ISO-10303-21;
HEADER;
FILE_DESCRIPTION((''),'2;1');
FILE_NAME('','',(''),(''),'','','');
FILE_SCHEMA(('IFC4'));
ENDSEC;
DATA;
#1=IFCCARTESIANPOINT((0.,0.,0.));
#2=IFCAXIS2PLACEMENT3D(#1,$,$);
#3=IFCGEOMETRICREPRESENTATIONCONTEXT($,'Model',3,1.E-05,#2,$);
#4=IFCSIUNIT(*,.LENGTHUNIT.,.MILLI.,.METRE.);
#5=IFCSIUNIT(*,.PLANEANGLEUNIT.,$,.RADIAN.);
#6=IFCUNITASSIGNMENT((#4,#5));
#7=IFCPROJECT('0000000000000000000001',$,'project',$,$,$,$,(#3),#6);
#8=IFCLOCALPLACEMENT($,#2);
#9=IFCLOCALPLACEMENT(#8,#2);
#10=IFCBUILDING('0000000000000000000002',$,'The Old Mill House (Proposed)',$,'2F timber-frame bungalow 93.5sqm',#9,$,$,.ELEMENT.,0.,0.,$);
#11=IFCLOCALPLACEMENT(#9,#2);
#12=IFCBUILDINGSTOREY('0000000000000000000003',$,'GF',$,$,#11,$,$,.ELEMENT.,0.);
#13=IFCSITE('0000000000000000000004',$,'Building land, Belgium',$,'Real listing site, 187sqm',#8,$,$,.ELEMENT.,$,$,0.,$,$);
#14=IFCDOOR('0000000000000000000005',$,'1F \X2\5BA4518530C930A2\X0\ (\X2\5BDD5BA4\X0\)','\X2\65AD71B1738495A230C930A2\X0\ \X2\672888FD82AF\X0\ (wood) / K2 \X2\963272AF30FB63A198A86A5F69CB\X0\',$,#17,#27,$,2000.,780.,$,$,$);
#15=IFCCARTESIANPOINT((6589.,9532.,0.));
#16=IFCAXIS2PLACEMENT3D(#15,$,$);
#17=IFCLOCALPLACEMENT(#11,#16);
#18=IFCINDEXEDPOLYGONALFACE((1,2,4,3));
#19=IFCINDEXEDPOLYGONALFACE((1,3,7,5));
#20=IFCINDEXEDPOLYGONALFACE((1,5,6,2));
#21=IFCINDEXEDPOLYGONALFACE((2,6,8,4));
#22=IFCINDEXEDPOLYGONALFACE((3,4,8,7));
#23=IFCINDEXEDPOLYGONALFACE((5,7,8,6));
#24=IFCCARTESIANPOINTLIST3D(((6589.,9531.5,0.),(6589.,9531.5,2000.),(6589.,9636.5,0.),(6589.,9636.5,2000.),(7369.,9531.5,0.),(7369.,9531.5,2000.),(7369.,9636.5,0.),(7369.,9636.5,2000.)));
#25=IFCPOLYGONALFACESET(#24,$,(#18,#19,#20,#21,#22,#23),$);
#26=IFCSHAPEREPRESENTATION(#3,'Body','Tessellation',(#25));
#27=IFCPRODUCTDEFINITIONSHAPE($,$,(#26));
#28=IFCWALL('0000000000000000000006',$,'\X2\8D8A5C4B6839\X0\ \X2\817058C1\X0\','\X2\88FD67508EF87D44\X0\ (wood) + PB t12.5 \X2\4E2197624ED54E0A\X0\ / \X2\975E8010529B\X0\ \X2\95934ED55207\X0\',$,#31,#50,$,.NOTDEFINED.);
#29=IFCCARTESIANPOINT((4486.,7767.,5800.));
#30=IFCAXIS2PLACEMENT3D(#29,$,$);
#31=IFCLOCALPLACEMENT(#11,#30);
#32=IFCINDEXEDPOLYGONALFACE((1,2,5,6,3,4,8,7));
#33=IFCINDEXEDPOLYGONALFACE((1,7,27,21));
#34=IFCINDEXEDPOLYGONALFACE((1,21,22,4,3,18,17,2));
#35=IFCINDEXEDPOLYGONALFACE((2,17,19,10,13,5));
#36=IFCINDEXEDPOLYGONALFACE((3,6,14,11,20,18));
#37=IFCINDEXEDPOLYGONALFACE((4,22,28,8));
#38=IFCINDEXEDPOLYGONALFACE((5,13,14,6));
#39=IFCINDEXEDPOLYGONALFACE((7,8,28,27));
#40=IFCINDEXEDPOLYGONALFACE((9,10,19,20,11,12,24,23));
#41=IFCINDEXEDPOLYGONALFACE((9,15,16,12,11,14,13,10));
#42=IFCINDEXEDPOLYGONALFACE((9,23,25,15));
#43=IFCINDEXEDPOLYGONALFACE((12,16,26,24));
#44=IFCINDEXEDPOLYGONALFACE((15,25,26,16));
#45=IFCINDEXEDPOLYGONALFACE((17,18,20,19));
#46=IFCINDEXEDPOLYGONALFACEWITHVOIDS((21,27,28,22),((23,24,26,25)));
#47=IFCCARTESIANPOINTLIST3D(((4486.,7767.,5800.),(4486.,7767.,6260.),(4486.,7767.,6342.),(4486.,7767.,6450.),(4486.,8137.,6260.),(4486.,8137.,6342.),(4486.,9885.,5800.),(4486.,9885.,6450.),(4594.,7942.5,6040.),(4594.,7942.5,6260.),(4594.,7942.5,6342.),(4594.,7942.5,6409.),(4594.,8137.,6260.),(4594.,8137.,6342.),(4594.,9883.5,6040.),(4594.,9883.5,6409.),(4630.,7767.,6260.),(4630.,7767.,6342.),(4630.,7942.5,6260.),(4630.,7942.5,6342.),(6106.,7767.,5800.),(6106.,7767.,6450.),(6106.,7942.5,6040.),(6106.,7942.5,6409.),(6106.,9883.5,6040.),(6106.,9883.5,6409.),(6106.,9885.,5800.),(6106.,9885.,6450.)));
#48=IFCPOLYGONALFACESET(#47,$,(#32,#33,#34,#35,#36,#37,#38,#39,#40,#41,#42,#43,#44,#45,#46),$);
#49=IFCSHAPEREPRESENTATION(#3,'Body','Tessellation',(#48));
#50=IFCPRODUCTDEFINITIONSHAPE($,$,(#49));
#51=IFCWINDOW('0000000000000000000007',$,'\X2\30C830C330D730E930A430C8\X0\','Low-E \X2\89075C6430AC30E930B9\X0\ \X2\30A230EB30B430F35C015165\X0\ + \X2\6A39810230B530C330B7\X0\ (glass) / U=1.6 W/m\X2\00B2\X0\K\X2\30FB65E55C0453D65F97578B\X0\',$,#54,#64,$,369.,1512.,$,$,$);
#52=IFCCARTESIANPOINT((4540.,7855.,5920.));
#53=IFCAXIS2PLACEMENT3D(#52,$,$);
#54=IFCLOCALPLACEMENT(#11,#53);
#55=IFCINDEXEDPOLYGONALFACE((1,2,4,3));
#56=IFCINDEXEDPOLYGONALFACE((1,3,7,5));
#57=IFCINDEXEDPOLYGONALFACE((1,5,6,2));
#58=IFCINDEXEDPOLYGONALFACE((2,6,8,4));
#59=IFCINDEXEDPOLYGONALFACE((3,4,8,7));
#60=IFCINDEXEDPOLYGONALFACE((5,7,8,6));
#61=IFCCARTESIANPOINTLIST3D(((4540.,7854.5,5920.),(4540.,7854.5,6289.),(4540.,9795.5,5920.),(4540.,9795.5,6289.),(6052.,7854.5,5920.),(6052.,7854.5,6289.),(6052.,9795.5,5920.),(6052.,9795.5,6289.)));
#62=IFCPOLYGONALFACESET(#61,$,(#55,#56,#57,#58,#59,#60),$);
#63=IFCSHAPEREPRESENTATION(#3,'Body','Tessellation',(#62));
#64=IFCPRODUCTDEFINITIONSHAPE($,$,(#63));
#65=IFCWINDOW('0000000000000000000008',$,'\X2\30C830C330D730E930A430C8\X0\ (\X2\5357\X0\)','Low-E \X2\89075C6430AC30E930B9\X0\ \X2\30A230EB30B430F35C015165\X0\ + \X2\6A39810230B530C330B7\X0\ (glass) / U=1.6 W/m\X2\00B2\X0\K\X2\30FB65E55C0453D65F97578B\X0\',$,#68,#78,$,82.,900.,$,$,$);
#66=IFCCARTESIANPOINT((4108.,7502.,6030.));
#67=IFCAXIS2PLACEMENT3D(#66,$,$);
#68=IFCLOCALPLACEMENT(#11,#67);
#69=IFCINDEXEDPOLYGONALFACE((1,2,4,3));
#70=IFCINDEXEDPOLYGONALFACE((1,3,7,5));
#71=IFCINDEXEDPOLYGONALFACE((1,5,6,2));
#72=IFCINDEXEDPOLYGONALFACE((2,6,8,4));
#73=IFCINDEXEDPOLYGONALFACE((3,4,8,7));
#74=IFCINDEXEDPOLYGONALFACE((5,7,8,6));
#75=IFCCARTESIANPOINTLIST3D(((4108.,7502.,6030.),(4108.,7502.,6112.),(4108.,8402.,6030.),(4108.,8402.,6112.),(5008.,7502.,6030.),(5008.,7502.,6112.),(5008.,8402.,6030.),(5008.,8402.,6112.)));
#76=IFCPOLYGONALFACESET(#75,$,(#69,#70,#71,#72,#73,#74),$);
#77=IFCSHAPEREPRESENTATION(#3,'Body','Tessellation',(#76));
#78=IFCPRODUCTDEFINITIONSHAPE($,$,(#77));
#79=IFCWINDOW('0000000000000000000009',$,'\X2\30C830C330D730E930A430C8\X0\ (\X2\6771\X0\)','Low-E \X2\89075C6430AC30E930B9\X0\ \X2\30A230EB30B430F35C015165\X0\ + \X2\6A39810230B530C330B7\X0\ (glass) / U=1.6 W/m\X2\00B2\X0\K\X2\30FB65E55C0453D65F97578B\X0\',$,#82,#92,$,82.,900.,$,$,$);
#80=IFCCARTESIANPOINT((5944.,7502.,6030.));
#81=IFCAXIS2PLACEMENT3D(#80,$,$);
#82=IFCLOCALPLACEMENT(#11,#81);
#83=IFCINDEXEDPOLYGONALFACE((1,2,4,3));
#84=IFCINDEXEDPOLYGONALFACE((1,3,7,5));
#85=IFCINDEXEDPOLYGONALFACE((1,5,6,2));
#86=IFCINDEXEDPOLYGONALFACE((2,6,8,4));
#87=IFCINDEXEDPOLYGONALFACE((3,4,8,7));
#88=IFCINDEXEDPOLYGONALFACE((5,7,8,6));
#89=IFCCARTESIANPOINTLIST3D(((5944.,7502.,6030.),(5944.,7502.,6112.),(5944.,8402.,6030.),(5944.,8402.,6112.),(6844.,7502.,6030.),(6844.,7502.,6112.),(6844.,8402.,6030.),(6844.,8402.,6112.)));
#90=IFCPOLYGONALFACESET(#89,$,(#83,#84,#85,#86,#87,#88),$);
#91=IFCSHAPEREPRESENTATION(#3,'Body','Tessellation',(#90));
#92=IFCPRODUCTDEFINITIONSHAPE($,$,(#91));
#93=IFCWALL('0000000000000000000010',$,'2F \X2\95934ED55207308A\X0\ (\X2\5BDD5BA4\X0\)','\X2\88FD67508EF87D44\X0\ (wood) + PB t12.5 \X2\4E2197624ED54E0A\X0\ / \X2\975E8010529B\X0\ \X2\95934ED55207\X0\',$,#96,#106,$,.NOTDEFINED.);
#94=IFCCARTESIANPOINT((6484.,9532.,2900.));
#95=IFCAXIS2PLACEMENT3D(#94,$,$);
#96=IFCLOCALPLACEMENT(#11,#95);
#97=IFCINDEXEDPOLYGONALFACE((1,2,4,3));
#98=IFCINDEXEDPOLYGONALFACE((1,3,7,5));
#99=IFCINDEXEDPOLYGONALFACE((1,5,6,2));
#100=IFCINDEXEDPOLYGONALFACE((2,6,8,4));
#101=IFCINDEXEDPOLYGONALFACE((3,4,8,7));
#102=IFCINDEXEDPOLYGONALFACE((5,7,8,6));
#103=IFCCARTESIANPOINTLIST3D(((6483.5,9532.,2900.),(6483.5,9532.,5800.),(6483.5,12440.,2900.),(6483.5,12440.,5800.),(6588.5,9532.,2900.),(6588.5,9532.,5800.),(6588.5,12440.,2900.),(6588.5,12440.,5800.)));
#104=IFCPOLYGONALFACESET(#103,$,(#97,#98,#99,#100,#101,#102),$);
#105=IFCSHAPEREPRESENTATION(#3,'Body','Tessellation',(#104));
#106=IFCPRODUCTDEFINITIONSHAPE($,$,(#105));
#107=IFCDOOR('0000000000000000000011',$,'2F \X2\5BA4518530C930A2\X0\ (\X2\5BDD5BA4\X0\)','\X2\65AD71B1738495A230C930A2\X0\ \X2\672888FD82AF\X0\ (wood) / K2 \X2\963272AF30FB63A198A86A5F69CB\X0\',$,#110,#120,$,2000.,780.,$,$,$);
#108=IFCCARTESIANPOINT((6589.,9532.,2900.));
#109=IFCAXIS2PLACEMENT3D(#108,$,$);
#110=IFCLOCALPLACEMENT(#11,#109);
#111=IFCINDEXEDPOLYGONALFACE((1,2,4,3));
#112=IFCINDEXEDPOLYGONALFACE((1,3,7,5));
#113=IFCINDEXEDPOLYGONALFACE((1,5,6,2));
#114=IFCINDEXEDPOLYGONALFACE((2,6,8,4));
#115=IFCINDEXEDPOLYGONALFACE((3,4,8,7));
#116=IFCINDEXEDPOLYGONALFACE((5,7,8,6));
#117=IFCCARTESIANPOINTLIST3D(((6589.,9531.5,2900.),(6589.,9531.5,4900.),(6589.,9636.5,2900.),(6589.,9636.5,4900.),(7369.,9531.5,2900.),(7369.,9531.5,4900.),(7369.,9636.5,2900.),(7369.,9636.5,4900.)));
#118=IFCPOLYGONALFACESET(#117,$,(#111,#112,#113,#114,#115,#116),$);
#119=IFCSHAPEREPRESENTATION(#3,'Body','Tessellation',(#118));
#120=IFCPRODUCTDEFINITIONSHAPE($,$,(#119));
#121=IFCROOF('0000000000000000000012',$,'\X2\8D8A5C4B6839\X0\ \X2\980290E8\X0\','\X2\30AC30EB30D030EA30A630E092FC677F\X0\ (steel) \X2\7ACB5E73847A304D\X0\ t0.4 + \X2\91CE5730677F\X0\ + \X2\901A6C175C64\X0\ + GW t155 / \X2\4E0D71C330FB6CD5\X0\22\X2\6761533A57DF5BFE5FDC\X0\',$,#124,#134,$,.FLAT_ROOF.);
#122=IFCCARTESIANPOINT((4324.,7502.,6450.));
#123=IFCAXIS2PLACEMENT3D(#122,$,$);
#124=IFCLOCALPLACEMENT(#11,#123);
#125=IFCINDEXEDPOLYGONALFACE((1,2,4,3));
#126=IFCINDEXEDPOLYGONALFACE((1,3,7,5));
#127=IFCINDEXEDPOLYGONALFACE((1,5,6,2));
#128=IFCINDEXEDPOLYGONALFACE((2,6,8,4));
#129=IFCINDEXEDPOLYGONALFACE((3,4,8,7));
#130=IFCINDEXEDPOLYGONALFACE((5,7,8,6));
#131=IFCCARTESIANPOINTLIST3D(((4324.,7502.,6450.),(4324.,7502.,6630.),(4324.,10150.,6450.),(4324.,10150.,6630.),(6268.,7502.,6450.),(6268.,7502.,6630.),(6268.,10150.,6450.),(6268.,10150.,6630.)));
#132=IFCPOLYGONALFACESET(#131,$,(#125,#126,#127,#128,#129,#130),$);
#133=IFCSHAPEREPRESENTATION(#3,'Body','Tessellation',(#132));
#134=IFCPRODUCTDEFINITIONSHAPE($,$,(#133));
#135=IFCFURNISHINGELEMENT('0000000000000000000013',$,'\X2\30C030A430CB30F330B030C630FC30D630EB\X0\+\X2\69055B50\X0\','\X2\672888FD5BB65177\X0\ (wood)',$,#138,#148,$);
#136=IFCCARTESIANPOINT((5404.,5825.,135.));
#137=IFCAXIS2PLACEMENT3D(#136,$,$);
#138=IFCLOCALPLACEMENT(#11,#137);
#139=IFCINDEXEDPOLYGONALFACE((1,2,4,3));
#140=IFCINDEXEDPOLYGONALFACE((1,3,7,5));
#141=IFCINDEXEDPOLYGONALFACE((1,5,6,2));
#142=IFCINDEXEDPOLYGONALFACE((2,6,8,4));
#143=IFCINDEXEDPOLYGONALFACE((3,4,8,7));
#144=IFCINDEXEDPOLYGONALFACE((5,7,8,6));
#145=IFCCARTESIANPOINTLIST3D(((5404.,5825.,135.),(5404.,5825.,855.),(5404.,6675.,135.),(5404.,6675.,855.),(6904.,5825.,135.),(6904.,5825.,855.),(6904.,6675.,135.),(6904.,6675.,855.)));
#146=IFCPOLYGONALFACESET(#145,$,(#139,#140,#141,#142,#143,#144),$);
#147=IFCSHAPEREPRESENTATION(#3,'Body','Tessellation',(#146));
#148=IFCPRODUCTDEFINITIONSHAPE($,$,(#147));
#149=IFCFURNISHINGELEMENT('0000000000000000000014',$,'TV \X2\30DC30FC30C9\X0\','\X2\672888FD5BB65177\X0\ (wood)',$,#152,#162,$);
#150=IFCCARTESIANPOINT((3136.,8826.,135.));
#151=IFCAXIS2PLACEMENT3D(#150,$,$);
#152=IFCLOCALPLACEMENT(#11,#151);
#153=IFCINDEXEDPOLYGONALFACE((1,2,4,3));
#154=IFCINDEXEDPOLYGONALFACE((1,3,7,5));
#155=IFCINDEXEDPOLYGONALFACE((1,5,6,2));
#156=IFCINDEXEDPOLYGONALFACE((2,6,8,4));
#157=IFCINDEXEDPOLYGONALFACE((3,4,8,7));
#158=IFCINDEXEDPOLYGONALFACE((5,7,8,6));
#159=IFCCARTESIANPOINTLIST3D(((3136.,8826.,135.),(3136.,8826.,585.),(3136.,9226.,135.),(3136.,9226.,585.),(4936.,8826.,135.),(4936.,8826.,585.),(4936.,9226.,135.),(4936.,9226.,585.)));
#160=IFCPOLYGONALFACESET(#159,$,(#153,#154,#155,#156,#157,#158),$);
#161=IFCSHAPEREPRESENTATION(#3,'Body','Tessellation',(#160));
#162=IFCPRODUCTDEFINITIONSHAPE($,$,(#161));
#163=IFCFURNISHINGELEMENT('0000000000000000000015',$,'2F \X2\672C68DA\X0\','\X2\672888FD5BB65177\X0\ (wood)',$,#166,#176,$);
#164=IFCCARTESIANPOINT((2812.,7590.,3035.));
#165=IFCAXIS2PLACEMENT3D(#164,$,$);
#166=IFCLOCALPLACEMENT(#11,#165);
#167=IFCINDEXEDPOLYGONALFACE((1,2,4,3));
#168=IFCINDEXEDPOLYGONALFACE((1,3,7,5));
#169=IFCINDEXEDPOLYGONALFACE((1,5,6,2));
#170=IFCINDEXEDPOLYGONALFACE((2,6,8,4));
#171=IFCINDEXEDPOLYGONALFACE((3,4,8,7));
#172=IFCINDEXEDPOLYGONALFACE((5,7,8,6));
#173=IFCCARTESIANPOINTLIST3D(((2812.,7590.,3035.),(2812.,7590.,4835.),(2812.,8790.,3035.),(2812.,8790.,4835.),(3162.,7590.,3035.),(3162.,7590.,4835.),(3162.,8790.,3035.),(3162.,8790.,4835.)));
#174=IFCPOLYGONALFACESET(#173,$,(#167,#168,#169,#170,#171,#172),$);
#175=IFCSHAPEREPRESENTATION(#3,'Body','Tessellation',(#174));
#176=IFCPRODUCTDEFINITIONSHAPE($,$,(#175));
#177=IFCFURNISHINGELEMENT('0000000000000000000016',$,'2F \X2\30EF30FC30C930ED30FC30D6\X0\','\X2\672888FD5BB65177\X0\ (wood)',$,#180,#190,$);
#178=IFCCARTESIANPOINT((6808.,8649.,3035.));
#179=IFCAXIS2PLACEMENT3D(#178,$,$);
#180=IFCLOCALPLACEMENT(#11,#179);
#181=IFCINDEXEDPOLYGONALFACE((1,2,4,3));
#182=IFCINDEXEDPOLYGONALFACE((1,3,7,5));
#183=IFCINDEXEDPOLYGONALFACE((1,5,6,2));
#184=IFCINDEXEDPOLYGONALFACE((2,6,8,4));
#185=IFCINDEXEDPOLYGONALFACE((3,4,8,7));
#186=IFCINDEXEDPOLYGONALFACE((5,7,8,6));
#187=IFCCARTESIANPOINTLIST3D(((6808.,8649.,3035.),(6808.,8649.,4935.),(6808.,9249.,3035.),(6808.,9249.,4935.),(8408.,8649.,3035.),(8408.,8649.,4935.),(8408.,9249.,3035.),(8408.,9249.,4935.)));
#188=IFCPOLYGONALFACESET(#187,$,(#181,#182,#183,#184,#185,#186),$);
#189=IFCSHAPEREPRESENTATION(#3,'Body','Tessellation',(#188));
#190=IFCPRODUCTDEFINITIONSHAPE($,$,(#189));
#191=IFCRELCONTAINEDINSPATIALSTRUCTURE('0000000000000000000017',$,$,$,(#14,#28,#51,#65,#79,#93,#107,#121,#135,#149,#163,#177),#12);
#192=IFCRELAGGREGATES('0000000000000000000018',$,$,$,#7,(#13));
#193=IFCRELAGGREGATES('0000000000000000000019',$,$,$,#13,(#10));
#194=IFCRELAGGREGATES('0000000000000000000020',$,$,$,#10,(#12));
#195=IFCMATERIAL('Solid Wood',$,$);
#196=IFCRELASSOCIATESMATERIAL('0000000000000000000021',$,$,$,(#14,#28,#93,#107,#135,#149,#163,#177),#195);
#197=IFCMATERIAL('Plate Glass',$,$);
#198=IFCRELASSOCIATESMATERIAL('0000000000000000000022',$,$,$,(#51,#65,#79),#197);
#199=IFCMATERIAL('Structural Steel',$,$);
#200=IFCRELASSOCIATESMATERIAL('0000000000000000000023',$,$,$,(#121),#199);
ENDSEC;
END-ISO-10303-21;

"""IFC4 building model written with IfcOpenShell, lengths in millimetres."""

from ifc_helpers import new_model, si_unit, frame, frame_2d, origin, place, context, project, spatial, rectangle, extrude, material, element, fill, save


model = new_model("IFC4")

# Units and contexts
model_context = context("Model", 3, precision=1e-05, world=origin())
ifc_project = project(units=[si_unit("LENGTHUNIT", "METRE", prefix="MILLI"), si_unit("PLANEANGLEUNIT", "RADIAN")], contexts=[model_context])

# Site, building, storey
site_placement = place(None, origin())
site = spatial("IfcSite", under=ifc_project, at=site_placement, Name="Building land, Belgium", ObjectType="Real listing site, 187sqm", CompositionType="ELEMENT", RefElevation=0.0)
building_placement = place(site_placement, origin())
building = spatial("IfcBuilding", under=site, at=building_placement, Name="The Old Mill House (Proposed)", ObjectType="2F timber-frame bungalow 93.5sqm", CompositionType="ELEMENT", ElevationOfRefHeight=0.0, ElevationOfTerrain=0.0)
storey_placement = place(building_placement, origin())
storey = spatial("IfcBuildingStorey", under=building, at=storey_placement, Name="GF", CompositionType="ELEMENT", Elevation=0.0)

# Shared definitions
ifc_material_1 = material(Name="Solid Wood")

# Door
door_1_placement = place(storey_placement, frame((6589.0, 9532.0, 0.0)))
element("IfcDoor", 1, at=door_1_placement, inside=storey, material=ifc_material_1, Name="1F 室内ドア (寝室)", Description="断熱玄関ドア 木製芯 (wood) / K2 防犯・採風機構", OverallHeight=2000.0, OverallWidth=780.0, context=model_context, shape_type="SweptSolid", body=[
    extrude(rectangle(XDim=780.0, YDim=105.0, at=frame_2d((390.0, 52.0))), frame((6589.0, 9532.0, 0.0)), (0.0, 0.0, 1.0), 2000.0),
])

# Wall, openings, windows
wall_1_placement = place(storey_placement, frame((4486.0, 7767.0, 5800.0)))
wall_1 = element("IfcWall", 2, at=wall_1_placement, inside=storey, material=ifc_material_1, Name="越屋根 腰壁", Description="製材軸組 (wood) + PB t12.5 両面仕上 / 非耐力 間仕切", PredefinedType="NOTDEFINED", context=model_context, shape_type="SweptSolid", body=[
    extrude(rectangle(XDim=1620.0, YDim=2118.0, at=frame_2d((810.0, 1059.0))), frame((4486.0, 7767.0, 5800.0)), (0.0, 0.0, 1.0), 650.0),
])
opening_1_placement = place(storey_placement, frame((4540.0, 7855.0, 5920.0)))
opening_1 = element("IfcOpeningElement", 3, at=opening_1_placement, cuts=wall_1, PredefinedType="NOTDEFINED", context=model_context, shape_type="SweptSolid", body=[
    extrude(rectangle(XDim=1512.0, YDim=1941.0, at=frame_2d((756.0, 970.0))), frame((4540.0, 7855.0, 5920.0)), (0.0, 0.0, 1.0), 369.0),
])
opening_2_placement = place(storey_placement, frame((4108.0, 7502.0, 6030.0)))
opening_2 = element("IfcOpeningElement", 4, at=opening_2_placement, cuts=wall_1, PredefinedType="NOTDEFINED", context=model_context, shape_type="SweptSolid", body=[
    extrude(rectangle(XDim=900.0, YDim=900.0, at=frame_2d((450.0, 450.0))), frame((4108.0, 7502.0, 6030.0)), (0.0, 0.0, 1.0), 82.0),
])
opening_3_placement = place(storey_placement, frame((5944.0, 7502.0, 6030.0)))
opening_3 = element("IfcOpeningElement", 5, at=opening_3_placement, cuts=wall_1, PredefinedType="NOTDEFINED", context=model_context, shape_type="SweptSolid", body=[
    extrude(rectangle(XDim=900.0, YDim=900.0, at=frame_2d((450.0, 450.0))), frame((5944.0, 7502.0, 6030.0)), (0.0, 0.0, 1.0), 82.0),
])
ifc_material_2 = material(Name="Plate Glass")
window_1_placement = place(storey_placement, frame((4540.0, 7855.0, 5920.0)))
window_1 = element("IfcWindow", 6, at=window_1_placement, inside=storey, material=ifc_material_2, Name="トップライト", Description="Low-E 複層ガラス アルゴン封入 + 樹脂サッシ (glass) / U=1.6 W/m²K・日射取得型", OverallHeight=369.0, OverallWidth=1512.0, context=model_context, shape_type="SweptSolid", body=[
    extrude(rectangle(XDim=1512.0, YDim=1941.0, at=frame_2d((756.0, 970.0))), frame((4540.0, 7855.0, 5920.0)), (0.0, 0.0, 1.0), 369.0),
])
fill(opening_1, window_1)
window_2_placement = place(storey_placement, frame((4108.0, 7502.0, 6030.0)))
window_2 = element("IfcWindow", 7, at=window_2_placement, inside=storey, material=ifc_material_2, Name="トップライト (南)", Description="Low-E 複層ガラス アルゴン封入 + 樹脂サッシ (glass) / U=1.6 W/m²K・日射取得型", OverallHeight=82.0, OverallWidth=900.0, context=model_context, shape_type="SweptSolid", body=[
    extrude(rectangle(XDim=900.0, YDim=900.0, at=frame_2d((450.0, 450.0))), frame((4108.0, 7502.0, 6030.0)), (0.0, 0.0, 1.0), 82.0),
])
fill(opening_2, window_2)
window_3_placement = place(storey_placement, frame((5944.0, 7502.0, 6030.0)))
window_3 = element("IfcWindow", 8, at=window_3_placement, inside=storey, material=ifc_material_2, Name="トップライト (東)", Description="Low-E 複層ガラス アルゴン封入 + 樹脂サッシ (glass) / U=1.6 W/m²K・日射取得型", OverallHeight=82.0, OverallWidth=900.0, context=model_context, shape_type="SweptSolid", body=[
    extrude(rectangle(XDim=900.0, YDim=900.0, at=frame_2d((450.0, 450.0))), frame((5944.0, 7502.0, 6030.0)), (0.0, 0.0, 1.0), 82.0),
])
fill(opening_3, window_3)

# Wall
wall_2_placement = place(storey_placement, frame((6484.0, 9532.0, 2900.0)))
element("IfcWall", 9, at=wall_2_placement, inside=storey, material=ifc_material_1, Name="2F 間仕切り (寝室)", Description="製材軸組 (wood) + PB t12.5 両面仕上 / 非耐力 間仕切", PredefinedType="NOTDEFINED", context=model_context, shape_type="SweptSolid", body=[
    extrude(rectangle(XDim=105.0, YDim=2908.0, at=frame_2d((52.0, 1454.0))), frame((6484.0, 9532.0, 2900.0)), (0.0, 0.0, 1.0), 2900.0),
])

# Door
door_2_placement = place(storey_placement, frame((6589.0, 9532.0, 2900.0)))
element("IfcDoor", 10, at=door_2_placement, inside=storey, material=ifc_material_1, Name="2F 室内ドア (寝室)", Description="断熱玄関ドア 木製芯 (wood) / K2 防犯・採風機構", OverallHeight=2000.0, OverallWidth=780.0, context=model_context, shape_type="SweptSolid", body=[
    extrude(rectangle(XDim=780.0, YDim=105.0, at=frame_2d((390.0, 52.0))), frame((6589.0, 9532.0, 2900.0)), (0.0, 0.0, 1.0), 2000.0),
])

# Roof
ifc_material_3 = material(Name="Structural Steel")
roof_placement = place(storey_placement, frame((4324.0, 7502.0, 6450.0)))
element("IfcRoof", 11, at=roof_placement, inside=storey, material=ifc_material_3, Name="越屋根 頂部", Description="ガルバリウム鋼板 (steel) 立平葺き t0.4 + 野地板 + 通気層 + GW t155 / 不燃・法22条区域対応", PredefinedType="FLAT_ROOF", context=model_context, shape_type="SweptSolid", body=[
    extrude(rectangle(XDim=1944.0, YDim=2648.0, at=frame_2d((972.0, 1324.0))), frame((4324.0, 7502.0, 6450.0)), (0.0, 0.0, 1.0), 180.0),
])

# Furnishing elements
furnishing_1_placement = place(storey_placement, frame((5404.0, 5825.0, 135.0)))
element("IfcFurnishingElement", 12, at=furnishing_1_placement, inside=storey, material=ifc_material_1, Name="ダイニングテーブル+椅子", Description="木製家具 (wood)", context=model_context, shape_type="SweptSolid", body=[
    extrude(rectangle(XDim=1500.0, YDim=850.0, at=frame_2d((750.0, 425.0))), frame((5404.0, 5825.0, 135.0)), (0.0, 0.0, 1.0), 720.0),
])
furnishing_2_placement = place(storey_placement, frame((3136.0, 8826.0, 135.0)))
element("IfcFurnishingElement", 13, at=furnishing_2_placement, inside=storey, material=ifc_material_1, Name="TV ボード", Description="木製家具 (wood)", context=model_context, shape_type="SweptSolid", body=[
    extrude(rectangle(XDim=1800.0, YDim=400.0, at=frame_2d((900.0, 200.0))), frame((3136.0, 8826.0, 135.0)), (0.0, 0.0, 1.0), 450.0),
])
furnishing_3_placement = place(storey_placement, frame((2812.0, 7590.0, 3035.0)))
element("IfcFurnishingElement", 14, at=furnishing_3_placement, inside=storey, material=ifc_material_1, Name="2F 本棚", Description="木製家具 (wood)", context=model_context, shape_type="SweptSolid", body=[
    extrude(rectangle(XDim=350.0, YDim=1200.0, at=frame_2d((175.0, 600.0))), frame((2812.0, 7590.0, 3035.0)), (0.0, 0.0, 1.0), 1800.0),
])
furnishing_4_placement = place(storey_placement, frame((6808.0, 8649.0, 3035.0)))
element("IfcFurnishingElement", 15, at=furnishing_4_placement, inside=storey, material=ifc_material_1, Name="2F ワードローブ", Description="木製家具 (wood)", context=model_context, shape_type="SweptSolid", body=[
    extrude(rectangle(XDim=1600.0, YDim=600.0, at=frame_2d((800.0, 300.0))), frame((6808.0, 8649.0, 3035.0)), (0.0, 0.0, 1.0), 1900.0),
])

save(model, "model.ifc")
